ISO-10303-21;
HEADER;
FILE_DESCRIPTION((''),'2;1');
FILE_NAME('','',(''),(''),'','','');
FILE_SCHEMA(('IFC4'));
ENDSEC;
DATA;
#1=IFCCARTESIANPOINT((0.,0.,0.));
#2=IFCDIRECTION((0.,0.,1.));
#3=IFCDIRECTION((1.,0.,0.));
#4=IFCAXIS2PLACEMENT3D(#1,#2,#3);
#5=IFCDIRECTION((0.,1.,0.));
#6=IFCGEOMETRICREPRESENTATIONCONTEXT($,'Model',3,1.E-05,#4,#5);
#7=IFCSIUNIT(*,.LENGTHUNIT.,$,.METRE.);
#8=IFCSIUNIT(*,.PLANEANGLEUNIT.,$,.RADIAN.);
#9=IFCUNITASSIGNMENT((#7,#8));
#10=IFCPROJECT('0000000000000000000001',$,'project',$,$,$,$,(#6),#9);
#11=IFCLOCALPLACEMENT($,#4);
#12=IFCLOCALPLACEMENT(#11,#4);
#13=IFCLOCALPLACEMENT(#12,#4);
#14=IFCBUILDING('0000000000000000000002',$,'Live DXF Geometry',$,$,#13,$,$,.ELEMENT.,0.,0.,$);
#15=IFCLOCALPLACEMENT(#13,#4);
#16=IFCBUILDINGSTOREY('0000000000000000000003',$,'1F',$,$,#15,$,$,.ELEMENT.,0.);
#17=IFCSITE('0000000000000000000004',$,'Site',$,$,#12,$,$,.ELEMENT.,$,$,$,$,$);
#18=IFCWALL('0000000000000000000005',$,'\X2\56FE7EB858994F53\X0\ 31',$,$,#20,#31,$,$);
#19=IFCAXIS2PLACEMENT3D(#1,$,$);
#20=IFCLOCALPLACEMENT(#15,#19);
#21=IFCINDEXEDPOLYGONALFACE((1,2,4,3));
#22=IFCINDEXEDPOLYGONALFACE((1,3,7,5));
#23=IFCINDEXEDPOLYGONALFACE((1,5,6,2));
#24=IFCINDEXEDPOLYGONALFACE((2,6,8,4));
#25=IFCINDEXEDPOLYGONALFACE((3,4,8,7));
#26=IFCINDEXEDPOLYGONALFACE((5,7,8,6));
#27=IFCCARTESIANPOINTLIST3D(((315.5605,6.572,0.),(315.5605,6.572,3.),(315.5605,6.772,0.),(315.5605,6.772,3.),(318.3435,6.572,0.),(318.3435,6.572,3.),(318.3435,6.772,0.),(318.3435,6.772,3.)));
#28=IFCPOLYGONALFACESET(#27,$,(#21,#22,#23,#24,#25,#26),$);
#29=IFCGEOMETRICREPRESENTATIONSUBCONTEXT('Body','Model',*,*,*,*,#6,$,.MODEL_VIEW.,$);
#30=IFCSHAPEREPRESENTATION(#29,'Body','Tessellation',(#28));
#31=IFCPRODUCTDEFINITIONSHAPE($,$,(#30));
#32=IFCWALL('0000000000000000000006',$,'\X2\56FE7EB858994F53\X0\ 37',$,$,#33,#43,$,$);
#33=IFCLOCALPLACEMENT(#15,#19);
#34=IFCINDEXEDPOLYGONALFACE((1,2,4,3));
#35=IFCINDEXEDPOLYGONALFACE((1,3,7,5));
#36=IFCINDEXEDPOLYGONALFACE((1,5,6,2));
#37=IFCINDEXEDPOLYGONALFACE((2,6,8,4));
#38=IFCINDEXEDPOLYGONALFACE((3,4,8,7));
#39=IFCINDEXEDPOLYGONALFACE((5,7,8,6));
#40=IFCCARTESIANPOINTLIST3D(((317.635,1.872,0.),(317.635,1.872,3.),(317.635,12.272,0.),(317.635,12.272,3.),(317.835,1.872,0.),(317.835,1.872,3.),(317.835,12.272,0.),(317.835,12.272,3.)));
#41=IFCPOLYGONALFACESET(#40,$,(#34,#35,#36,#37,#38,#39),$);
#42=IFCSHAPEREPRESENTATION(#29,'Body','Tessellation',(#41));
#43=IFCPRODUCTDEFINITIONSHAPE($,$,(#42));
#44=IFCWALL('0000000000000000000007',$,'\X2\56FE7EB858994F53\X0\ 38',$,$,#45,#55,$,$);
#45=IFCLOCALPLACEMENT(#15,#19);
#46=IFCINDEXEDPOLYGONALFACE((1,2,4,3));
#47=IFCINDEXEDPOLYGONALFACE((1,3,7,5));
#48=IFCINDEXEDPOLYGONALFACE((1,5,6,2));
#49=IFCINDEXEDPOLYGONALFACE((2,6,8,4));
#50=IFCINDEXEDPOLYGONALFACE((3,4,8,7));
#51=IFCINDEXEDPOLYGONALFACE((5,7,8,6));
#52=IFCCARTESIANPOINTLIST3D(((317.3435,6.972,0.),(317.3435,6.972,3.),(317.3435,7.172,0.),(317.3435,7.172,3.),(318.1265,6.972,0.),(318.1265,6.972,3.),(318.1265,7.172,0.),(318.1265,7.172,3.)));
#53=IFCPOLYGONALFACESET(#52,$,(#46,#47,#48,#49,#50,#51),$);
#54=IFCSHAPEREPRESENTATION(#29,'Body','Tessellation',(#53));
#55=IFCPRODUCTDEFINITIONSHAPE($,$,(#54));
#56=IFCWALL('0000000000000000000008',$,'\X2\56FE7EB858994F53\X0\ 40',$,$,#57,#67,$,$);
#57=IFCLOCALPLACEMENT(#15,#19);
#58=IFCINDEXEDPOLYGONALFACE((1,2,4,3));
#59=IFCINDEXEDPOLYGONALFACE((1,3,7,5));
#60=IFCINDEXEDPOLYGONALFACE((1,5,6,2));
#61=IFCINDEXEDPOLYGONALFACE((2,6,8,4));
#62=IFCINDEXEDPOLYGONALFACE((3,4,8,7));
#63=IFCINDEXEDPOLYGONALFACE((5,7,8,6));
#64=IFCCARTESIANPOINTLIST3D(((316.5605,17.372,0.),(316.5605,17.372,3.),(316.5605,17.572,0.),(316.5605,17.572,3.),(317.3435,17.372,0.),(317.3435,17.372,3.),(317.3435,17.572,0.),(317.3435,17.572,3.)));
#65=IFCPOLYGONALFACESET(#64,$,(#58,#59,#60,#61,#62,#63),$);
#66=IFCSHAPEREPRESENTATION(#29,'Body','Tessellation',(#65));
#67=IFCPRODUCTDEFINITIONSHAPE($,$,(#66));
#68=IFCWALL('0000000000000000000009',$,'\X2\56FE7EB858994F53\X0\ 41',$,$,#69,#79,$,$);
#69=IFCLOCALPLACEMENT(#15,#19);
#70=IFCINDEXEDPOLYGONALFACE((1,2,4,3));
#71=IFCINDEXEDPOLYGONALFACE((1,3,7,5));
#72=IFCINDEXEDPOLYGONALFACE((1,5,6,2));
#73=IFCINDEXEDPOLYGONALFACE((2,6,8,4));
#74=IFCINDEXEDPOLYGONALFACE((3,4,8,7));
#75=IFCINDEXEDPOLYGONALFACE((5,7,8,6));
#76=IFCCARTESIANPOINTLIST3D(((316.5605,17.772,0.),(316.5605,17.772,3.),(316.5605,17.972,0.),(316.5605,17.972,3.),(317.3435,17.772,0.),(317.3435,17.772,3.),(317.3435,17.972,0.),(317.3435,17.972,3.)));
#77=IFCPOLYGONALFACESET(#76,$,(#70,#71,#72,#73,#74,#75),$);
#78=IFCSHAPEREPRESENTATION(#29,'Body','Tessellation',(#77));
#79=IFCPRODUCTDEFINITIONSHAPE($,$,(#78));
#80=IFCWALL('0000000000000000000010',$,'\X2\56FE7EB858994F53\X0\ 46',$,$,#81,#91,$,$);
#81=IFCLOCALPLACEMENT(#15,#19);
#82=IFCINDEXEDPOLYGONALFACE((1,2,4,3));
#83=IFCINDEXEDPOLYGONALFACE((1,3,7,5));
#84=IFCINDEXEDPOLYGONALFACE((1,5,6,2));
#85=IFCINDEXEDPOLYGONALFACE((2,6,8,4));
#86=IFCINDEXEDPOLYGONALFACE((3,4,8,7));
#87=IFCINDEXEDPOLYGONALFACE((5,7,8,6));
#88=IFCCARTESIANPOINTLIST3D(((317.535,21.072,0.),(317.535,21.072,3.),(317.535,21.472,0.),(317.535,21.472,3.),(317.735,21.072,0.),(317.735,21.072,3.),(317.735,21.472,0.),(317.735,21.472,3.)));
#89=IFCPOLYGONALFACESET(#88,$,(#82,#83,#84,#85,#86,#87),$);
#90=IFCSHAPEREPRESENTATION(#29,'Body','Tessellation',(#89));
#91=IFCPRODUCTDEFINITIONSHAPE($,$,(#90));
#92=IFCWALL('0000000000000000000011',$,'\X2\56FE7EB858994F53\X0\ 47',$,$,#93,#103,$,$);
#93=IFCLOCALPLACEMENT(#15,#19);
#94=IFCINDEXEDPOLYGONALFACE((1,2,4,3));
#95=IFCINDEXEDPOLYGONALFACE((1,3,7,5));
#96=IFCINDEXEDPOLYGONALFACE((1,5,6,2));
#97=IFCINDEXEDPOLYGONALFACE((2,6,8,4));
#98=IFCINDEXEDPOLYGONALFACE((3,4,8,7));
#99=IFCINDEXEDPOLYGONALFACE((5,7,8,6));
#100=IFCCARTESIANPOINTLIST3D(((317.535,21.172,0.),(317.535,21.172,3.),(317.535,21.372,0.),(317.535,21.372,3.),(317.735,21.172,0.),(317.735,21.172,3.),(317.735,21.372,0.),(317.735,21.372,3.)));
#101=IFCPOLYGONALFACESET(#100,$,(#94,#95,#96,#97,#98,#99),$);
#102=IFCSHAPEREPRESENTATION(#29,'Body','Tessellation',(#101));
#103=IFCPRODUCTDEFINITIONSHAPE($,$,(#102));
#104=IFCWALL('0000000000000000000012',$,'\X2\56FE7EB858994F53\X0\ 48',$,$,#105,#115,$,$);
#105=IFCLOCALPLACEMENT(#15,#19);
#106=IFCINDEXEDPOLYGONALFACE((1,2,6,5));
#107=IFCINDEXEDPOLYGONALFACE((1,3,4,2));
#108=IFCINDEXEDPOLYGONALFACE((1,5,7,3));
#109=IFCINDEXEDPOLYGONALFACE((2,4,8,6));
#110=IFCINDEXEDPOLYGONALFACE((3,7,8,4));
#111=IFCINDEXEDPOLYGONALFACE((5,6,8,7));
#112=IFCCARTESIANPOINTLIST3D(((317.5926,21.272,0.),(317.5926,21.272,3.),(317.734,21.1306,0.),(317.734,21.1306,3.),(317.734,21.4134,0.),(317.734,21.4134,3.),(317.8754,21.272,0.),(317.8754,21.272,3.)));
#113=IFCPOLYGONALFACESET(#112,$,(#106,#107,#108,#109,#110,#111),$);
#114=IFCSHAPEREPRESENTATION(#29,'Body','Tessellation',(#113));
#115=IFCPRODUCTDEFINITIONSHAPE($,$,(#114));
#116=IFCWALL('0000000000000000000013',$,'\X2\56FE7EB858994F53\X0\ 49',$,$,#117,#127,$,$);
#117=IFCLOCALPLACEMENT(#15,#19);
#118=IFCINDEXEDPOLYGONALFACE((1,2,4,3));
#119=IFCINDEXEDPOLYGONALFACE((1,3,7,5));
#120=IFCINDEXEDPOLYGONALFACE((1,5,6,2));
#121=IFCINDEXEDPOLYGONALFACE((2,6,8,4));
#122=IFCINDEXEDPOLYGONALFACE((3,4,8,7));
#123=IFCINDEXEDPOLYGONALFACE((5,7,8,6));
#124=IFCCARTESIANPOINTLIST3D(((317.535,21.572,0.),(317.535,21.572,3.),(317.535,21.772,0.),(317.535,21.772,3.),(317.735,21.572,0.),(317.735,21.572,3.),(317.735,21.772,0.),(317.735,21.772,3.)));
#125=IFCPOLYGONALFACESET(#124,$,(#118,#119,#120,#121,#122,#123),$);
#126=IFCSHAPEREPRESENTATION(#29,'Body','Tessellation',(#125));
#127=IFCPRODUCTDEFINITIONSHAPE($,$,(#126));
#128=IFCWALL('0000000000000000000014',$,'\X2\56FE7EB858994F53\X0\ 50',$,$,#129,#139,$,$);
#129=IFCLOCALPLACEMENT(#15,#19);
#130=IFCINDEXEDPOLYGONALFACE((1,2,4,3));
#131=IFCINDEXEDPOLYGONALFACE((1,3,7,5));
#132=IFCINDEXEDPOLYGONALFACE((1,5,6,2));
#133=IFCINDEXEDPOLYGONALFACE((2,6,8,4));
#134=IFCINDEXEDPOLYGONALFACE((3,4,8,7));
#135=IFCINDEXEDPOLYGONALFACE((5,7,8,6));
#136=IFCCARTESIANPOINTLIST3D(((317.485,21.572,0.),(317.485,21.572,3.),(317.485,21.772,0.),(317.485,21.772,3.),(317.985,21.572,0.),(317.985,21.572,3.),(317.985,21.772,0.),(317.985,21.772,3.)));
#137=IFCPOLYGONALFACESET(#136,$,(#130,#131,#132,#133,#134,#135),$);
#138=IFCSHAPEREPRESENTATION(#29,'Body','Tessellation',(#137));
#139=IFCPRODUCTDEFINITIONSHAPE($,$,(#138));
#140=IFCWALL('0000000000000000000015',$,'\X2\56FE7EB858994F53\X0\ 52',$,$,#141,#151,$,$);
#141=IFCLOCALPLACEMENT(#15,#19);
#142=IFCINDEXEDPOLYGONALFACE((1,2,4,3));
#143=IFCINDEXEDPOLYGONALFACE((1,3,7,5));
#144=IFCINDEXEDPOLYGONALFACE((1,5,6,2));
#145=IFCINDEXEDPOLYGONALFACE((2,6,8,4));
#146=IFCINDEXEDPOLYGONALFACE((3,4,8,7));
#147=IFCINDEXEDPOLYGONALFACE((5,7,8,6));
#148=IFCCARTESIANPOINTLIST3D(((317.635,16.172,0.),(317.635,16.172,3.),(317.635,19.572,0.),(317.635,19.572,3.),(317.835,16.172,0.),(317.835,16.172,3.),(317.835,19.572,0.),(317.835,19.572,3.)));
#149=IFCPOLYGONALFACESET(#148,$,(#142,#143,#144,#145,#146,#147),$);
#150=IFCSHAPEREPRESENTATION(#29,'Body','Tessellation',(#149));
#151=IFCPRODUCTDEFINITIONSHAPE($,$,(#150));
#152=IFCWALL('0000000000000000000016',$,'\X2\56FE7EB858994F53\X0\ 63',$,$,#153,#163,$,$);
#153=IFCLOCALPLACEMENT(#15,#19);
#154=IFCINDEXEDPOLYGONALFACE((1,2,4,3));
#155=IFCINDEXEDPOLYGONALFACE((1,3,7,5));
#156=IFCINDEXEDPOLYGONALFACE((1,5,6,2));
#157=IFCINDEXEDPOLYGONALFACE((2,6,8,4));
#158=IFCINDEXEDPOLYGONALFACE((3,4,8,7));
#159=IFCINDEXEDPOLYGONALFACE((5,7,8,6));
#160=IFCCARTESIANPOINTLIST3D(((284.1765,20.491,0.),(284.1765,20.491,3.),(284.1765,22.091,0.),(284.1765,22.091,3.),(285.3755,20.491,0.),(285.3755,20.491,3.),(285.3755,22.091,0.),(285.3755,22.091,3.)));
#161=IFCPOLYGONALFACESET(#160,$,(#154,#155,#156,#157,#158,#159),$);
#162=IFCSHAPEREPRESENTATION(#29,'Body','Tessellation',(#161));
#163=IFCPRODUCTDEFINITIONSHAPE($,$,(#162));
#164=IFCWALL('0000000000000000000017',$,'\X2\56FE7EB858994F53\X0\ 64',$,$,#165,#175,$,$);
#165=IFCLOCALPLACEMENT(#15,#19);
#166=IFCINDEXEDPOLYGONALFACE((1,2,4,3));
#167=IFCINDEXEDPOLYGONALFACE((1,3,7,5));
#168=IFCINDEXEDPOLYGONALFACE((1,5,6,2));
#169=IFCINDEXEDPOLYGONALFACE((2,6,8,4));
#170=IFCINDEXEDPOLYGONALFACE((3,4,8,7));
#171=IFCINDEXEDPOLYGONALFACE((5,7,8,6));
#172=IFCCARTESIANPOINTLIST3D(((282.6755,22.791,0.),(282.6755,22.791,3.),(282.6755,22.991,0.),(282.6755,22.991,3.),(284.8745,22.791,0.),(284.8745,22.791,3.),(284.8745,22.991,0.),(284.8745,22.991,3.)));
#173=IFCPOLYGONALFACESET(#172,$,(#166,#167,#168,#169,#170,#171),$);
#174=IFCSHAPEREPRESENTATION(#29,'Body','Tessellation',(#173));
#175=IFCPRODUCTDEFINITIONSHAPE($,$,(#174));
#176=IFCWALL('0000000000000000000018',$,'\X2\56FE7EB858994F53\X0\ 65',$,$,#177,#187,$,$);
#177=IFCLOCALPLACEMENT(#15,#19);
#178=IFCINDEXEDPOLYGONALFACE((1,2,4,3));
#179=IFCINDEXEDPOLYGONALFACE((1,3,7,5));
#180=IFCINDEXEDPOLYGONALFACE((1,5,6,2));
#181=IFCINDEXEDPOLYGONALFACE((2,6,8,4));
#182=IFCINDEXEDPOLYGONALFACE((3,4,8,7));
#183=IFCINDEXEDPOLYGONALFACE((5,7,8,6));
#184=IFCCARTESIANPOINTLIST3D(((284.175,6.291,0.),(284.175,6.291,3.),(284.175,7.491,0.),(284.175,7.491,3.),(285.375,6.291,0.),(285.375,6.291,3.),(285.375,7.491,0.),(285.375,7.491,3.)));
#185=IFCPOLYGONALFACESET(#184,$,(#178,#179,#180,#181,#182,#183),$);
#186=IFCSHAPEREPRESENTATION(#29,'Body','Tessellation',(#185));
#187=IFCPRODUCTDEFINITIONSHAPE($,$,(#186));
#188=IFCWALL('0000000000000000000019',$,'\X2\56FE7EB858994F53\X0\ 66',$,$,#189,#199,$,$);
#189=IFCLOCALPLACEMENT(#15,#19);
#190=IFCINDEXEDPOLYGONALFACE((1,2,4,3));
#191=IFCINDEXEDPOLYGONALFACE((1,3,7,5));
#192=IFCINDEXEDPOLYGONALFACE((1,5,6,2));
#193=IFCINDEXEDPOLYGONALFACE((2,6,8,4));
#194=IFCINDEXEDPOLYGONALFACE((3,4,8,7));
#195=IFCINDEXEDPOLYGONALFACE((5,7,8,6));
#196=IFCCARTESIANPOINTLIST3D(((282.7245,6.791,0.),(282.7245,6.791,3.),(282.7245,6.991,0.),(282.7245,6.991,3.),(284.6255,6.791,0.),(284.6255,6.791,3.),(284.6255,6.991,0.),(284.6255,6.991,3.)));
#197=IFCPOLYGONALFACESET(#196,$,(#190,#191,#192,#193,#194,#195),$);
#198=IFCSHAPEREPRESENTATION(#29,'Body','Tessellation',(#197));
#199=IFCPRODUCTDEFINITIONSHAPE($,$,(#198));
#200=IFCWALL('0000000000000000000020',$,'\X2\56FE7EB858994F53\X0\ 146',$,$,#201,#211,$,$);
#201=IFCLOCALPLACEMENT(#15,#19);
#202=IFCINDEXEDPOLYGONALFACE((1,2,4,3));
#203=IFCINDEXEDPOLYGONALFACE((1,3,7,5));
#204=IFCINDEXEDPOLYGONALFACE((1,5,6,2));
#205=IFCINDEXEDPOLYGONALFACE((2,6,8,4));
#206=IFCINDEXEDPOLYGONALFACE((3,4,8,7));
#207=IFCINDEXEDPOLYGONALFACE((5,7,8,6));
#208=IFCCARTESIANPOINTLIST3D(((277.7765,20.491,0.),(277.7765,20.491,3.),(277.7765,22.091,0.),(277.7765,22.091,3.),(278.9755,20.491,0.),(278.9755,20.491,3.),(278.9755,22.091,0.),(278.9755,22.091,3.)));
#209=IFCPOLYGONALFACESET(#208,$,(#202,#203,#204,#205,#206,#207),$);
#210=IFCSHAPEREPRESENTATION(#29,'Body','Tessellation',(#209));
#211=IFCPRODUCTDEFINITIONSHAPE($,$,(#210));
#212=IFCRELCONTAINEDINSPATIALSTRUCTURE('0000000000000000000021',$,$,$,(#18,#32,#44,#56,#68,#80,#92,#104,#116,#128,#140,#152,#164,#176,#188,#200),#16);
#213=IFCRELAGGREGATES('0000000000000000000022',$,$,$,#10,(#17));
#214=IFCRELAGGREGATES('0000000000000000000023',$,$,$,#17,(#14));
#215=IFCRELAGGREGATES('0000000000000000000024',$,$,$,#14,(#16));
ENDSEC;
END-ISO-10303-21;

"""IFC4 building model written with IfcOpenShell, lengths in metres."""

from ifc_helpers import new_model, si_unit, direction, frame, frame_2d, origin_with_axes, place, context, subcontext, project, spatial, rectangle, extrude, element, save


model = new_model("IFC4")

# Units and contexts
model_context = context("Model", 3, precision=1e-05, world=origin_with_axes(), true_north=direction((0.0, 1.0, 0.0)))
body_context = subcontext(model_context, "Body", "Model", "MODEL_VIEW")
ifc_project = project(units=[si_unit("LENGTHUNIT", "METRE"), si_unit("PLANEANGLEUNIT", "RADIAN")], contexts=[model_context])

# Site, building, storey
placement = place(None, origin_with_axes())
site_placement = place(placement, origin_with_axes())
site = spatial("IfcSite", under=ifc_project, at=site_placement, Name="Site", CompositionType="ELEMENT")
building_placement = place(site_placement, origin_with_axes())
building = spatial("IfcBuilding", under=site, at=building_placement, Name="Live DXF Geometry", CompositionType="ELEMENT", ElevationOfRefHeight=0.0, ElevationOfTerrain=0.0)
storey_placement = place(building_placement, origin_with_axes())
storey = spatial("IfcBuildingStorey", under=building, at=storey_placement, Name="1F", CompositionType="ELEMENT", Elevation=0.0)

# Walls
wall_1_placement = place(storey_placement, frame((316.952, 6.672, 0.0), z_axis=(0.0, 0.0, 1.0), x_axis=(1.0, 0.0, 0.0)))
element("IfcWall", 1, at=wall_1_placement, inside=storey, Name="图纸墙体 31", context=body_context, shape_type="SweptSolid", body=[
    extrude(rectangle(XDim=2.783, YDim=0.2, at=frame_2d((0.0, 0.0), x_axis=(1.0, 0.0, 0.0))), frame((0.0, 0.0, 0.0), z_axis=(0.0, 0.0, 1.0)), (0.0, 0.0, 1.0), 3.0),
])
wall_2_placement = place(storey_placement, frame((317.735, 7.072, 0.0), z_axis=(0.0, 0.0, 1.0), x_axis=(0.0, 1.0, 0.0)))
element("IfcWall", 2, at=wall_2_placement, inside=storey, Name="图纸墙体 37", context=body_context, shape_type="SweptSolid", body=[
    extrude(rectangle(XDim=10.4, YDim=0.2, at=frame_2d((0.0, 0.0), x_axis=(1.0, 0.0, 0.0))), frame((0.0, 0.0, 0.0), z_axis=(0.0, 0.0, 1.0)), (0.0, 0.0, 1.0), 3.0),
])
for number, where, z_axis, x_axis, name in (
    (3, (317.735, 7.072, 0.0), (0.0, 0.0, 1.0), (-1.0, 0.0, 0.0), "图纸墙体 38"),
    (4, (316.952, 17.472, 0.0), (0.0, 0.0, 1.0), (1.0, 0.0, 0.0), "图纸墙体 40"),
    (5, (316.952, 17.872, 0.0), (0.0, 0.0, 1.0), (1.0, 0.0, 0.0), "图纸墙体 41"),
):
    element("IfcWall", number, at=place(storey_placement, frame(where, z_axis=z_axis, x_axis=x_axis)), inside=storey, Name=name, context=body_context, shape_type="SweptSolid", body=[
        extrude(rectangle(XDim=0.783, YDim=0.2, at=frame_2d((0.0, 0.0), x_axis=(1.0, 0.0, 0.0))), frame((0.0, 0.0, 0.0), z_axis=(0.0, 0.0, 1.0)), (0.0, 0.0, 1.0), 3.0),
    ])
wall_3_placement = place(storey_placement, frame((317.635, 21.272, 0.0), z_axis=(0.0, 0.0, 1.0), x_axis=(0.0, 1.0, 0.0)))
element("IfcWall", 6, at=wall_3_placement, inside=storey, Name="图纸墙体 46", context=body_context, shape_type="SweptSolid", body=[
    extrude(rectangle(XDim=0.4, YDim=0.2, at=frame_2d((0.0, 0.0), x_axis=(1.0, 0.0, 0.0))), frame((0.0, 0.0, 0.0), z_axis=(0.0, 0.0, 1.0)), (0.0, 0.0, 1.0), 3.0),
])
for number, where, z_axis, x_axis, name in (
    (7, (317.635, 21.272, 0.0), (0.0, 0.0, 1.0), (1.0, 0.0, 0.0), "图纸墙体 47"),
    (8, (317.734, 21.272, 0.0), (0.0, 0.0, 1.0), (0.707107, -0.707107, 0.0), "图纸墙体 48"),
    (9, (317.635, 21.672, 0.0), (0.0, 0.0, 1.0), (1.0, 0.0, 0.0), "图纸墙体 49"),
):
    element("IfcWall", number, at=place(storey_placement, frame(where, z_axis=z_axis, x_axis=x_axis)), inside=storey, Name=name, context=body_context, shape_type="SweptSolid", body=[
        extrude(rectangle(XDim=0.2, YDim=0.2, at=frame_2d((0.0, 0.0), x_axis=(1.0, 0.0, 0.0))), frame((0.0, 0.0, 0.0), z_axis=(0.0, 0.0, 1.0)), (0.0, 0.0, 1.0), 3.0),
    ])
wall_4_placement = place(storey_placement, frame((317.735, 21.672, 0.0), z_axis=(0.0, 0.0, 1.0), x_axis=(1.0, 0.0, 0.0)))
element("IfcWall", 10, at=wall_4_placement, inside=storey, Name="图纸墙体 50", context=body_context, shape_type="SweptSolid", body=[
    extrude(rectangle(XDim=0.5, YDim=0.2, at=frame_2d((0.0, 0.0), x_axis=(1.0, 0.0, 0.0))), frame((0.0, 0.0, 0.0), z_axis=(0.0, 0.0, 1.0)), (0.0, 0.0, 1.0), 3.0),
])
wall_5_placement = place(storey_placement, frame((317.735, 17.872, 0.0), z_axis=(0.0, 0.0, 1.0), x_axis=(0.0, 1.0, 0.0)))
element("IfcWall", 11, at=wall_5_placement, inside=storey, Name="图纸墙体 52", context=body_context, shape_type="SweptSolid", body=[
    extrude(rectangle(XDim=3.4, YDim=0.2, at=frame_2d((0.0, 0.0), x_axis=(1.0, 0.0, 0.0))), frame((0.0, 0.0, 0.0), z_axis=(0.0, 0.0, 1.0)), (0.0, 0.0, 1.0), 3.0),
])
wall_6_placement = place(storey_placement, frame((284.776, 21.291, 0.0), z_axis=(0.0, 0.0, 1.0), x_axis=(1.0, 0.0, 0.0)))
element("IfcWall", 12, at=wall_6_placement, inside=storey, Name="图纸墙体 63", context=body_context, shape_type="SweptSolid", body=[
    extrude(rectangle(XDim=1.199, YDim=1.6, at=frame_2d((0.0, 0.0), x_axis=(1.0, 0.0, 0.0))), frame((0.0, 0.0, 0.0), z_axis=(0.0, 0.0, 1.0)), (0.0, 0.0, 1.0), 3.0),
])
wall_7_placement = place(storey_placement, frame((283.775, 22.891, 0.0), z_axis=(0.0, 0.0, 1.0), x_axis=(1.0, 0.0, 0.0)))
element("IfcWall", 13, at=wall_7_placement, inside=storey, Name="图纸墙体 64", context=body_context, shape_type="SweptSolid", body=[
    extrude(rectangle(XDim=2.199, YDim=0.2, at=frame_2d((0.0, 0.0), x_axis=(1.0, 0.0, 0.0))), frame((0.0, 0.0, 0.0), z_axis=(0.0, 0.0, 1.0)), (0.0, 0.0, 1.0), 3.0),
])
wall_8_placement = place(storey_placement, frame((284.775, 6.891, 0.0), z_axis=(0.0, 0.0, 1.0), x_axis=(1.0, 0.0, 0.0)))
element("IfcWall", 14, at=wall_8_placement, inside=storey, Name="图纸墙体 65", context=body_context, shape_type="SweptSolid", body=[
    extrude(rectangle(XDim=1.2, YDim=1.2, at=frame_2d((0.0, 0.0), x_axis=(1.0, 0.0, 0.0))), frame((0.0, 0.0, 0.0), z_axis=(0.0, 0.0, 1.0)), (0.0, 0.0, 1.0), 3.0),
])
wall_9_placement = place(storey_placement, frame((283.675, 6.891, 0.0), z_axis=(0.0, 0.0, 1.0), x_axis=(1.0, 0.0, 0.0)))
element("IfcWall", 15, at=wall_9_placement, inside=storey, Name="图纸墙体 66", context=body_context, shape_type="SweptSolid", body=[
    extrude(rectangle(XDim=1.901, YDim=0.2, at=frame_2d((0.0, 0.0), x_axis=(1.0, 0.0, 0.0))), frame((0.0, 0.0, 0.0), z_axis=(0.0, 0.0, 1.0)), (0.0, 0.0, 1.0), 3.0),
])
wall_10_placement = place(storey_placement, frame((278.376, 21.291, 0.0), z_axis=(0.0, 0.0, 1.0), x_axis=(1.0, 0.0, 0.0)))
element("IfcWall", 16, at=wall_10_placement, inside=storey, Name="图纸墙体 146", context=body_context, shape_type="SweptSolid", body=[
    extrude(rectangle(XDim=1.199, YDim=1.6, at=frame_2d((0.0, 0.0), x_axis=(1.0, 0.0, 0.0))), frame((0.0, 0.0, 0.0), z_axis=(0.0, 0.0, 1.0)), (0.0, 0.0, 1.0), 3.0),
])

save(model, "model.ifc")
